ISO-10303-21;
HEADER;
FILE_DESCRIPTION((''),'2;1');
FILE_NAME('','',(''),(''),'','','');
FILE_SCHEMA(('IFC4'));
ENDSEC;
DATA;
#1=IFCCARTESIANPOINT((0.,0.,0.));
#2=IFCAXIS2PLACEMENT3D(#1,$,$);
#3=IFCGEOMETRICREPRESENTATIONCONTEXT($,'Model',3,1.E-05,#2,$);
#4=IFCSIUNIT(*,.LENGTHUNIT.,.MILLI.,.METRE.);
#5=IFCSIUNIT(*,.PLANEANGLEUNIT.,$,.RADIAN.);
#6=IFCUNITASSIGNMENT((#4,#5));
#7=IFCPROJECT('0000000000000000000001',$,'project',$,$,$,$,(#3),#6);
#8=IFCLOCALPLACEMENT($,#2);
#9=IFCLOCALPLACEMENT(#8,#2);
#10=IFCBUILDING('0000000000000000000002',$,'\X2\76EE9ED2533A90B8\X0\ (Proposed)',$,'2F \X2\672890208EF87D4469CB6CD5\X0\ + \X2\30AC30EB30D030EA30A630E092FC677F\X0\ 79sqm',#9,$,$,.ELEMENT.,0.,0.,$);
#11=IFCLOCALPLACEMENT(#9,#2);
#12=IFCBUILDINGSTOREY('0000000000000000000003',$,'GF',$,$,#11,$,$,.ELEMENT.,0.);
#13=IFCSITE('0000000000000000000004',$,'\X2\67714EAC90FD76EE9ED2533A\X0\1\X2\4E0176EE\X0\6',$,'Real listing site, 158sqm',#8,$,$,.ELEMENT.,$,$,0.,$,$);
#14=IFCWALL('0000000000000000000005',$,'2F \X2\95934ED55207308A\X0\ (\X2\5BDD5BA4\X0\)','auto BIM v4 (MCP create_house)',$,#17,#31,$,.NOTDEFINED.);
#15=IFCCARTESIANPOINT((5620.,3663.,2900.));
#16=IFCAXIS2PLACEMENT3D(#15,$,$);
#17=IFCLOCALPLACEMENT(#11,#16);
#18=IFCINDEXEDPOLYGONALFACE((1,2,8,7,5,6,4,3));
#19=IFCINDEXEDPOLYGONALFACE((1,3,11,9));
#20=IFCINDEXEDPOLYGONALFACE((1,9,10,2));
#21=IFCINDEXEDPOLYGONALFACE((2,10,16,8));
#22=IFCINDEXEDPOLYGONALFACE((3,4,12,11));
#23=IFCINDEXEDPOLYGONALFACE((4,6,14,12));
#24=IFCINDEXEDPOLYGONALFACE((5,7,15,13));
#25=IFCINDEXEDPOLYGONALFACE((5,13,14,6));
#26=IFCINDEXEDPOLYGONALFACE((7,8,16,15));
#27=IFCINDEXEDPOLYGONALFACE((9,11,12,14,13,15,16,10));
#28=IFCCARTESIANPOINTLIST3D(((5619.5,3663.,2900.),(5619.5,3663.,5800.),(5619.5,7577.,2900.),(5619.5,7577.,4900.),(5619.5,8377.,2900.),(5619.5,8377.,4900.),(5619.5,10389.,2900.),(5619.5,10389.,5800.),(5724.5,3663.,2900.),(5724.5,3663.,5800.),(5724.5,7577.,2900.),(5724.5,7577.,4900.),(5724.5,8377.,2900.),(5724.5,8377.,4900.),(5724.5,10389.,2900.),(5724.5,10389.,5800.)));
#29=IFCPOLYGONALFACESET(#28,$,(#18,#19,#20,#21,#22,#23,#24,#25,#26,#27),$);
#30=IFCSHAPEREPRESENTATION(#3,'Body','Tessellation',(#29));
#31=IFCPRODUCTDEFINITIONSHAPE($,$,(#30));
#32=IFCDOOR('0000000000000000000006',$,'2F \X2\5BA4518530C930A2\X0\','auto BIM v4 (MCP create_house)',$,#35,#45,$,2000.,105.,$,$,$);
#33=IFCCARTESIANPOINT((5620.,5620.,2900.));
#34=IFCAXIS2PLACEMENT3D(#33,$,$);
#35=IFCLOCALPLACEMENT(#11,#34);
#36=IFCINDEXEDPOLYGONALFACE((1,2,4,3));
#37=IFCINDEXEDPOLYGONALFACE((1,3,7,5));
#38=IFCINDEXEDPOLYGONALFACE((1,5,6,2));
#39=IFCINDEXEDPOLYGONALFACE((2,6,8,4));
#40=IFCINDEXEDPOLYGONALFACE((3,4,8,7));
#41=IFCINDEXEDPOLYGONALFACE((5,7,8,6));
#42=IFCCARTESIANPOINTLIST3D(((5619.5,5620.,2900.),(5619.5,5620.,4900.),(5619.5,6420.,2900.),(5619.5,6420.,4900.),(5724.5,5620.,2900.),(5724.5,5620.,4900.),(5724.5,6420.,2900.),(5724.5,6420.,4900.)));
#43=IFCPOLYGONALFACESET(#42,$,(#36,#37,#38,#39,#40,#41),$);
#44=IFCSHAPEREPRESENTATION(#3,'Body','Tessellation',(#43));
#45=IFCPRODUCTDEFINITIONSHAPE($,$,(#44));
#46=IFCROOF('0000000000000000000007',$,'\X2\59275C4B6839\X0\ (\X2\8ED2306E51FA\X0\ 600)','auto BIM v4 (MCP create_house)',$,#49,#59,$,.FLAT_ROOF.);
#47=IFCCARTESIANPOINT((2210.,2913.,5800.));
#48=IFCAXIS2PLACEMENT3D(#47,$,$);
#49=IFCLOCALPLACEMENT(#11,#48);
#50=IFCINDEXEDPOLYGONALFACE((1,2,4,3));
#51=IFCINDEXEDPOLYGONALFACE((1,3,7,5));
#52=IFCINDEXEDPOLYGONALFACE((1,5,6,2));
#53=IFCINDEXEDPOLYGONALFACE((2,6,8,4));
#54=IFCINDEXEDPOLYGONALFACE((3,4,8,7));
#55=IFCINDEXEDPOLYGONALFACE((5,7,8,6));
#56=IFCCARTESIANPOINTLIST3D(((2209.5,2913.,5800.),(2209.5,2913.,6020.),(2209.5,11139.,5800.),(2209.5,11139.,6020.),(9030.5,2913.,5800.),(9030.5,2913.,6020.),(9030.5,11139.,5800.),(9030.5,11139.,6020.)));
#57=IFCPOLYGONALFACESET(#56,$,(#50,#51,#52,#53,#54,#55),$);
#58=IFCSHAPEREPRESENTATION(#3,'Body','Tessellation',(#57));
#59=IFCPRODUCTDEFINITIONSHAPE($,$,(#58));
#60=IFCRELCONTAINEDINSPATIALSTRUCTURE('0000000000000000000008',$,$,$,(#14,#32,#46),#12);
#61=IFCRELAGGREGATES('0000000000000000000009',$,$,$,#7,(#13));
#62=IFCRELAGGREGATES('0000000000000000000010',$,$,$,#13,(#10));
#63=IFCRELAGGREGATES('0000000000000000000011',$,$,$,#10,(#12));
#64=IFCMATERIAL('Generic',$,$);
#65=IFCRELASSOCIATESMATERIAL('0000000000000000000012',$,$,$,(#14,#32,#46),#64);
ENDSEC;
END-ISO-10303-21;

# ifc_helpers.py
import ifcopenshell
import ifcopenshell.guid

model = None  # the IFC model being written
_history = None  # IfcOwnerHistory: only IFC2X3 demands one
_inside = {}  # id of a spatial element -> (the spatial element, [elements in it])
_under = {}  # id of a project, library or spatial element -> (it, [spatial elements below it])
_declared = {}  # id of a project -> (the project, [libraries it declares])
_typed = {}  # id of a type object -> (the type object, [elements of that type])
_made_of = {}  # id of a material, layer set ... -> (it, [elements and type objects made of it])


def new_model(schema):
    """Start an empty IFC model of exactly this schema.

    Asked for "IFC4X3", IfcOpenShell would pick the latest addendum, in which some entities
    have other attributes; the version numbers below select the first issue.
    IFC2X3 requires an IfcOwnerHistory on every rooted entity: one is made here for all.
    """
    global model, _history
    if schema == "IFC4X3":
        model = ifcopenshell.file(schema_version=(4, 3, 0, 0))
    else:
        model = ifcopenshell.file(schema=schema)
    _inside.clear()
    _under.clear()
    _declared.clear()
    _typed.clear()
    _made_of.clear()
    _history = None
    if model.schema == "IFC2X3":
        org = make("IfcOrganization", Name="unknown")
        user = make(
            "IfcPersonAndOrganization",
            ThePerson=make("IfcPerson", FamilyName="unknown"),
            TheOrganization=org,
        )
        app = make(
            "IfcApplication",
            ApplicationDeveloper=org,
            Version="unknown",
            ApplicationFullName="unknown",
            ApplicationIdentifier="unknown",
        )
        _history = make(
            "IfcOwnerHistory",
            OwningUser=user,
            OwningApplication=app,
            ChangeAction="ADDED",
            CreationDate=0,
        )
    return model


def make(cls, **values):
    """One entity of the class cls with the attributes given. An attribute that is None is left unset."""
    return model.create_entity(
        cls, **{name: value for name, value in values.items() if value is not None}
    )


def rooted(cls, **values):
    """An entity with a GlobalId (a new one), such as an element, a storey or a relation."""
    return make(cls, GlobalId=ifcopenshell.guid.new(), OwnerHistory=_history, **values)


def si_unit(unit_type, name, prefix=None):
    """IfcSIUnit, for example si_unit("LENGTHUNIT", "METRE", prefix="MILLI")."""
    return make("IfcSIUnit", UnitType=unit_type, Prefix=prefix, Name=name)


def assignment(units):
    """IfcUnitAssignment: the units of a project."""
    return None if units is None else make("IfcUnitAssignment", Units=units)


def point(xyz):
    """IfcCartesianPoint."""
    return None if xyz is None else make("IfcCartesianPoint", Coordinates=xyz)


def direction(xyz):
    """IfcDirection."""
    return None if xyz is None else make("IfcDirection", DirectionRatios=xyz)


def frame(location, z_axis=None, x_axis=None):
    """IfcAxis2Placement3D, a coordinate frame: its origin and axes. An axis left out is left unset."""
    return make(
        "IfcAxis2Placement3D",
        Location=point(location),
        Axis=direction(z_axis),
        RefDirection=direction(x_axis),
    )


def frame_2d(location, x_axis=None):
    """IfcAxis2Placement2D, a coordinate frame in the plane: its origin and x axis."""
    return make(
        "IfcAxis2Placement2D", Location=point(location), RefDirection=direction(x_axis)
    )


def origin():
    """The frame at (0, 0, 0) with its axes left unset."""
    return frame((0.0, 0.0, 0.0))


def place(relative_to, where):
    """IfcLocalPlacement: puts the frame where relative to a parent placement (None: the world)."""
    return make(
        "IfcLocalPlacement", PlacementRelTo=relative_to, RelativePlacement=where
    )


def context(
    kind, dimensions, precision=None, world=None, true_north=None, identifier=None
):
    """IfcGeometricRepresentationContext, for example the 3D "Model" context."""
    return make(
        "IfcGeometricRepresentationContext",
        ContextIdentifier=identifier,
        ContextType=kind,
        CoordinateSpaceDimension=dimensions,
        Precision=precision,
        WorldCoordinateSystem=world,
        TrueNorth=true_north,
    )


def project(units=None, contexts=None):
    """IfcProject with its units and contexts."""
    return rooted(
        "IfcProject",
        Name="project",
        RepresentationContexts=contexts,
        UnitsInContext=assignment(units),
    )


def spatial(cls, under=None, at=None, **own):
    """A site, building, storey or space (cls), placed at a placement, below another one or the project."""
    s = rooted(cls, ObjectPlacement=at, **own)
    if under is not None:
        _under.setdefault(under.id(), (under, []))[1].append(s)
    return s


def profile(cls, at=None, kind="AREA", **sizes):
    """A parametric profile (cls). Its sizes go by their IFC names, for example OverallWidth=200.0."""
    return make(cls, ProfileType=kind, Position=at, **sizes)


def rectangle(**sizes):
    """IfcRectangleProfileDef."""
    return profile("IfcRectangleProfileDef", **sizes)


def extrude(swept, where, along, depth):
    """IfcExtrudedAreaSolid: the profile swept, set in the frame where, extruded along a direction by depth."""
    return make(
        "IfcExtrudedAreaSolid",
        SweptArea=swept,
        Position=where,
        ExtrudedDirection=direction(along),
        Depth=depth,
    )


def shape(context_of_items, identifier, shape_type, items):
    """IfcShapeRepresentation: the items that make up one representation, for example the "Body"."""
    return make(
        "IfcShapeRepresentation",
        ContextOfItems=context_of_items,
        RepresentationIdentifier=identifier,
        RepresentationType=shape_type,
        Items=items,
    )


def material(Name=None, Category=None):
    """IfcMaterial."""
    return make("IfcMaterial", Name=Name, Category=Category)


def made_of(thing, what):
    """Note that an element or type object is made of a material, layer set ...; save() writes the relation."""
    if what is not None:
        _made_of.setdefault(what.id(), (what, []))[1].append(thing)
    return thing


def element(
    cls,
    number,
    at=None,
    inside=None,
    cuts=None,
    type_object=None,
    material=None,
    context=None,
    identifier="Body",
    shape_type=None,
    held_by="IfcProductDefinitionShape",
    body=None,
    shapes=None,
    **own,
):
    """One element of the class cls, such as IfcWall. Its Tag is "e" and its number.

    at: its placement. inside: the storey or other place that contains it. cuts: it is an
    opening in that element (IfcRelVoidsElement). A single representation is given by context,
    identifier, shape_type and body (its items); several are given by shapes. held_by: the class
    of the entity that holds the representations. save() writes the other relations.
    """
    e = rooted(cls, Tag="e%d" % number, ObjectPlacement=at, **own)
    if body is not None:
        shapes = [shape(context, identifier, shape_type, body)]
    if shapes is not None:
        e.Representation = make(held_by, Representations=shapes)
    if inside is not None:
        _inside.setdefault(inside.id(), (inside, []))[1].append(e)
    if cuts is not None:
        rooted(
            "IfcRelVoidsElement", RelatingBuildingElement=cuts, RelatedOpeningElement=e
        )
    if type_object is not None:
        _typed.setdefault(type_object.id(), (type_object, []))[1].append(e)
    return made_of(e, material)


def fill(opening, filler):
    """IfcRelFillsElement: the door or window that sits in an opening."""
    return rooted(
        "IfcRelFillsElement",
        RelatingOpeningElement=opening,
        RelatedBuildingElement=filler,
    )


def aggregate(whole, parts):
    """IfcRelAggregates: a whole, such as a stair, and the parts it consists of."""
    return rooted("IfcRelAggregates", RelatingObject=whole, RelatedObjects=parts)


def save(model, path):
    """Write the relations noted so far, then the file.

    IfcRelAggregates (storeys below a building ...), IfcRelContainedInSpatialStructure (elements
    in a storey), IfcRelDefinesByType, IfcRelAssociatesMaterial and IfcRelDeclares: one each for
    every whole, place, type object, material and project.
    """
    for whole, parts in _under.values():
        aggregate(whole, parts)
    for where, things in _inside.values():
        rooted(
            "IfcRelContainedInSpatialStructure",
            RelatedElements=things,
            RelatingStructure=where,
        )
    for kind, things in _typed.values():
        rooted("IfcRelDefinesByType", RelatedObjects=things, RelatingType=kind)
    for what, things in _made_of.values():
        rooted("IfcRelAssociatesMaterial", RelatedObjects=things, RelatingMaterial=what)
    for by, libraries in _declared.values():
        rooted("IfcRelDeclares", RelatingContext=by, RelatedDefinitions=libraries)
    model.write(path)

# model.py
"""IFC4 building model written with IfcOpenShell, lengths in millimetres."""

from ifc_helpers import new_model, si_unit, frame, frame_2d, origin, place, context, project, spatial, rectangle, extrude, material, element, fill, save


model = new_model("IFC4")

# Units and contexts
model_context = context("Model", 3, precision=1e-05, world=origin())
ifc_project = project(units=[si_unit("LENGTHUNIT", "METRE", prefix="MILLI"), si_unit("PLANEANGLEUNIT", "RADIAN")], contexts=[model_context])

# Site, building, storey
site_placement = place(None, origin())
site = spatial("IfcSite", under=ifc_project, at=site_placement, Name="東京都目黒区1丁目6", ObjectType="Real listing site, 158sqm", CompositionType="ELEMENT", RefElevation=0.0)
building_placement = place(site_placement, origin())
building = spatial("IfcBuilding", under=site, at=building_placement, Name="目黒区邸 (Proposed)", ObjectType="2F 木造軸組構法 + ガルバリウム鋼板 79sqm", CompositionType="ELEMENT", ElevationOfRefHeight=0.0, ElevationOfTerrain=0.0)
storey_placement = place(building_placement, origin())
storey = spatial("IfcBuildingStorey", under=building, at=storey_placement, Name="GF", CompositionType="ELEMENT", Elevation=0.0)

# Shared definitions
ifc_material = material(Name="Generic")

# Wall, opening, door
wall_1_placement = place(storey_placement, frame((5620.0, 3663.0, 2900.0)))
wall_1 = element("IfcWall", 1, at=wall_1_placement, inside=storey, material=ifc_material, Name="2F 間仕切り (寝室)", Description="auto BIM v4 (MCP create_house)", PredefinedType="NOTDEFINED", context=model_context, shape_type="SweptSolid", body=[
    extrude(rectangle(XDim=105.0, YDim=6726.0, at=frame_2d((52.0, 3363.0))), frame((5620.0, 3663.0, 2900.0)), (0.0, 0.0, 1.0), 2900.0),
])
opening_1_placement = place(storey_placement, frame((5620.0, 5620.0, 2900.0)))
opening_1 = element("IfcOpeningElement", 2, at=opening_1_placement, cuts=wall_1, PredefinedType="NOTDEFINED", context=model_context, shape_type="SweptSolid", body=[
    extrude(rectangle(XDim=105.0, YDim=800.0, at=frame_2d((52.0, 400.0))), frame((5620.0, 5620.0, 2900.0)), (0.0, 0.0, 1.0), 2000.0),
])
door_1_placement = place(storey_placement, frame((5620.0, 5620.0, 2900.0)))
door_1 = element("IfcDoor", 3, at=door_1_placement, inside=storey, material=ifc_material, Name="2F 室内ドア", Description="auto BIM v4 (MCP create_house)", OverallHeight=2000.0, OverallWidth=105.0, context=model_context, shape_type="SweptSolid", body=[
    extrude(rectangle(XDim=105.0, YDim=800.0, at=frame_2d((52.0, 400.0))), frame((5620.0, 5620.0, 2900.0)), (0.0, 0.0, 1.0), 2000.0),
])
fill(opening_1, door_1)

# Roof
roof_placement = place(storey_placement, frame((2210.0, 2913.0, 5800.0)))
element("IfcRoof", 4, at=roof_placement, inside=storey, material=ifc_material, Name="大屋根 (軒の出 600)", Description="auto BIM v4 (MCP create_house)", PredefinedType="FLAT_ROOF", context=model_context, shape_type="SweptSolid", body=[
    extrude(rectangle(XDim=6821.0, YDim=8226.0, at=frame_2d((3410.0, 4113.0))), frame((2210.0, 2913.0, 5800.0)), (0.0, 0.0, 1.0), 220.0),
])

save(model, "model.ifc")
